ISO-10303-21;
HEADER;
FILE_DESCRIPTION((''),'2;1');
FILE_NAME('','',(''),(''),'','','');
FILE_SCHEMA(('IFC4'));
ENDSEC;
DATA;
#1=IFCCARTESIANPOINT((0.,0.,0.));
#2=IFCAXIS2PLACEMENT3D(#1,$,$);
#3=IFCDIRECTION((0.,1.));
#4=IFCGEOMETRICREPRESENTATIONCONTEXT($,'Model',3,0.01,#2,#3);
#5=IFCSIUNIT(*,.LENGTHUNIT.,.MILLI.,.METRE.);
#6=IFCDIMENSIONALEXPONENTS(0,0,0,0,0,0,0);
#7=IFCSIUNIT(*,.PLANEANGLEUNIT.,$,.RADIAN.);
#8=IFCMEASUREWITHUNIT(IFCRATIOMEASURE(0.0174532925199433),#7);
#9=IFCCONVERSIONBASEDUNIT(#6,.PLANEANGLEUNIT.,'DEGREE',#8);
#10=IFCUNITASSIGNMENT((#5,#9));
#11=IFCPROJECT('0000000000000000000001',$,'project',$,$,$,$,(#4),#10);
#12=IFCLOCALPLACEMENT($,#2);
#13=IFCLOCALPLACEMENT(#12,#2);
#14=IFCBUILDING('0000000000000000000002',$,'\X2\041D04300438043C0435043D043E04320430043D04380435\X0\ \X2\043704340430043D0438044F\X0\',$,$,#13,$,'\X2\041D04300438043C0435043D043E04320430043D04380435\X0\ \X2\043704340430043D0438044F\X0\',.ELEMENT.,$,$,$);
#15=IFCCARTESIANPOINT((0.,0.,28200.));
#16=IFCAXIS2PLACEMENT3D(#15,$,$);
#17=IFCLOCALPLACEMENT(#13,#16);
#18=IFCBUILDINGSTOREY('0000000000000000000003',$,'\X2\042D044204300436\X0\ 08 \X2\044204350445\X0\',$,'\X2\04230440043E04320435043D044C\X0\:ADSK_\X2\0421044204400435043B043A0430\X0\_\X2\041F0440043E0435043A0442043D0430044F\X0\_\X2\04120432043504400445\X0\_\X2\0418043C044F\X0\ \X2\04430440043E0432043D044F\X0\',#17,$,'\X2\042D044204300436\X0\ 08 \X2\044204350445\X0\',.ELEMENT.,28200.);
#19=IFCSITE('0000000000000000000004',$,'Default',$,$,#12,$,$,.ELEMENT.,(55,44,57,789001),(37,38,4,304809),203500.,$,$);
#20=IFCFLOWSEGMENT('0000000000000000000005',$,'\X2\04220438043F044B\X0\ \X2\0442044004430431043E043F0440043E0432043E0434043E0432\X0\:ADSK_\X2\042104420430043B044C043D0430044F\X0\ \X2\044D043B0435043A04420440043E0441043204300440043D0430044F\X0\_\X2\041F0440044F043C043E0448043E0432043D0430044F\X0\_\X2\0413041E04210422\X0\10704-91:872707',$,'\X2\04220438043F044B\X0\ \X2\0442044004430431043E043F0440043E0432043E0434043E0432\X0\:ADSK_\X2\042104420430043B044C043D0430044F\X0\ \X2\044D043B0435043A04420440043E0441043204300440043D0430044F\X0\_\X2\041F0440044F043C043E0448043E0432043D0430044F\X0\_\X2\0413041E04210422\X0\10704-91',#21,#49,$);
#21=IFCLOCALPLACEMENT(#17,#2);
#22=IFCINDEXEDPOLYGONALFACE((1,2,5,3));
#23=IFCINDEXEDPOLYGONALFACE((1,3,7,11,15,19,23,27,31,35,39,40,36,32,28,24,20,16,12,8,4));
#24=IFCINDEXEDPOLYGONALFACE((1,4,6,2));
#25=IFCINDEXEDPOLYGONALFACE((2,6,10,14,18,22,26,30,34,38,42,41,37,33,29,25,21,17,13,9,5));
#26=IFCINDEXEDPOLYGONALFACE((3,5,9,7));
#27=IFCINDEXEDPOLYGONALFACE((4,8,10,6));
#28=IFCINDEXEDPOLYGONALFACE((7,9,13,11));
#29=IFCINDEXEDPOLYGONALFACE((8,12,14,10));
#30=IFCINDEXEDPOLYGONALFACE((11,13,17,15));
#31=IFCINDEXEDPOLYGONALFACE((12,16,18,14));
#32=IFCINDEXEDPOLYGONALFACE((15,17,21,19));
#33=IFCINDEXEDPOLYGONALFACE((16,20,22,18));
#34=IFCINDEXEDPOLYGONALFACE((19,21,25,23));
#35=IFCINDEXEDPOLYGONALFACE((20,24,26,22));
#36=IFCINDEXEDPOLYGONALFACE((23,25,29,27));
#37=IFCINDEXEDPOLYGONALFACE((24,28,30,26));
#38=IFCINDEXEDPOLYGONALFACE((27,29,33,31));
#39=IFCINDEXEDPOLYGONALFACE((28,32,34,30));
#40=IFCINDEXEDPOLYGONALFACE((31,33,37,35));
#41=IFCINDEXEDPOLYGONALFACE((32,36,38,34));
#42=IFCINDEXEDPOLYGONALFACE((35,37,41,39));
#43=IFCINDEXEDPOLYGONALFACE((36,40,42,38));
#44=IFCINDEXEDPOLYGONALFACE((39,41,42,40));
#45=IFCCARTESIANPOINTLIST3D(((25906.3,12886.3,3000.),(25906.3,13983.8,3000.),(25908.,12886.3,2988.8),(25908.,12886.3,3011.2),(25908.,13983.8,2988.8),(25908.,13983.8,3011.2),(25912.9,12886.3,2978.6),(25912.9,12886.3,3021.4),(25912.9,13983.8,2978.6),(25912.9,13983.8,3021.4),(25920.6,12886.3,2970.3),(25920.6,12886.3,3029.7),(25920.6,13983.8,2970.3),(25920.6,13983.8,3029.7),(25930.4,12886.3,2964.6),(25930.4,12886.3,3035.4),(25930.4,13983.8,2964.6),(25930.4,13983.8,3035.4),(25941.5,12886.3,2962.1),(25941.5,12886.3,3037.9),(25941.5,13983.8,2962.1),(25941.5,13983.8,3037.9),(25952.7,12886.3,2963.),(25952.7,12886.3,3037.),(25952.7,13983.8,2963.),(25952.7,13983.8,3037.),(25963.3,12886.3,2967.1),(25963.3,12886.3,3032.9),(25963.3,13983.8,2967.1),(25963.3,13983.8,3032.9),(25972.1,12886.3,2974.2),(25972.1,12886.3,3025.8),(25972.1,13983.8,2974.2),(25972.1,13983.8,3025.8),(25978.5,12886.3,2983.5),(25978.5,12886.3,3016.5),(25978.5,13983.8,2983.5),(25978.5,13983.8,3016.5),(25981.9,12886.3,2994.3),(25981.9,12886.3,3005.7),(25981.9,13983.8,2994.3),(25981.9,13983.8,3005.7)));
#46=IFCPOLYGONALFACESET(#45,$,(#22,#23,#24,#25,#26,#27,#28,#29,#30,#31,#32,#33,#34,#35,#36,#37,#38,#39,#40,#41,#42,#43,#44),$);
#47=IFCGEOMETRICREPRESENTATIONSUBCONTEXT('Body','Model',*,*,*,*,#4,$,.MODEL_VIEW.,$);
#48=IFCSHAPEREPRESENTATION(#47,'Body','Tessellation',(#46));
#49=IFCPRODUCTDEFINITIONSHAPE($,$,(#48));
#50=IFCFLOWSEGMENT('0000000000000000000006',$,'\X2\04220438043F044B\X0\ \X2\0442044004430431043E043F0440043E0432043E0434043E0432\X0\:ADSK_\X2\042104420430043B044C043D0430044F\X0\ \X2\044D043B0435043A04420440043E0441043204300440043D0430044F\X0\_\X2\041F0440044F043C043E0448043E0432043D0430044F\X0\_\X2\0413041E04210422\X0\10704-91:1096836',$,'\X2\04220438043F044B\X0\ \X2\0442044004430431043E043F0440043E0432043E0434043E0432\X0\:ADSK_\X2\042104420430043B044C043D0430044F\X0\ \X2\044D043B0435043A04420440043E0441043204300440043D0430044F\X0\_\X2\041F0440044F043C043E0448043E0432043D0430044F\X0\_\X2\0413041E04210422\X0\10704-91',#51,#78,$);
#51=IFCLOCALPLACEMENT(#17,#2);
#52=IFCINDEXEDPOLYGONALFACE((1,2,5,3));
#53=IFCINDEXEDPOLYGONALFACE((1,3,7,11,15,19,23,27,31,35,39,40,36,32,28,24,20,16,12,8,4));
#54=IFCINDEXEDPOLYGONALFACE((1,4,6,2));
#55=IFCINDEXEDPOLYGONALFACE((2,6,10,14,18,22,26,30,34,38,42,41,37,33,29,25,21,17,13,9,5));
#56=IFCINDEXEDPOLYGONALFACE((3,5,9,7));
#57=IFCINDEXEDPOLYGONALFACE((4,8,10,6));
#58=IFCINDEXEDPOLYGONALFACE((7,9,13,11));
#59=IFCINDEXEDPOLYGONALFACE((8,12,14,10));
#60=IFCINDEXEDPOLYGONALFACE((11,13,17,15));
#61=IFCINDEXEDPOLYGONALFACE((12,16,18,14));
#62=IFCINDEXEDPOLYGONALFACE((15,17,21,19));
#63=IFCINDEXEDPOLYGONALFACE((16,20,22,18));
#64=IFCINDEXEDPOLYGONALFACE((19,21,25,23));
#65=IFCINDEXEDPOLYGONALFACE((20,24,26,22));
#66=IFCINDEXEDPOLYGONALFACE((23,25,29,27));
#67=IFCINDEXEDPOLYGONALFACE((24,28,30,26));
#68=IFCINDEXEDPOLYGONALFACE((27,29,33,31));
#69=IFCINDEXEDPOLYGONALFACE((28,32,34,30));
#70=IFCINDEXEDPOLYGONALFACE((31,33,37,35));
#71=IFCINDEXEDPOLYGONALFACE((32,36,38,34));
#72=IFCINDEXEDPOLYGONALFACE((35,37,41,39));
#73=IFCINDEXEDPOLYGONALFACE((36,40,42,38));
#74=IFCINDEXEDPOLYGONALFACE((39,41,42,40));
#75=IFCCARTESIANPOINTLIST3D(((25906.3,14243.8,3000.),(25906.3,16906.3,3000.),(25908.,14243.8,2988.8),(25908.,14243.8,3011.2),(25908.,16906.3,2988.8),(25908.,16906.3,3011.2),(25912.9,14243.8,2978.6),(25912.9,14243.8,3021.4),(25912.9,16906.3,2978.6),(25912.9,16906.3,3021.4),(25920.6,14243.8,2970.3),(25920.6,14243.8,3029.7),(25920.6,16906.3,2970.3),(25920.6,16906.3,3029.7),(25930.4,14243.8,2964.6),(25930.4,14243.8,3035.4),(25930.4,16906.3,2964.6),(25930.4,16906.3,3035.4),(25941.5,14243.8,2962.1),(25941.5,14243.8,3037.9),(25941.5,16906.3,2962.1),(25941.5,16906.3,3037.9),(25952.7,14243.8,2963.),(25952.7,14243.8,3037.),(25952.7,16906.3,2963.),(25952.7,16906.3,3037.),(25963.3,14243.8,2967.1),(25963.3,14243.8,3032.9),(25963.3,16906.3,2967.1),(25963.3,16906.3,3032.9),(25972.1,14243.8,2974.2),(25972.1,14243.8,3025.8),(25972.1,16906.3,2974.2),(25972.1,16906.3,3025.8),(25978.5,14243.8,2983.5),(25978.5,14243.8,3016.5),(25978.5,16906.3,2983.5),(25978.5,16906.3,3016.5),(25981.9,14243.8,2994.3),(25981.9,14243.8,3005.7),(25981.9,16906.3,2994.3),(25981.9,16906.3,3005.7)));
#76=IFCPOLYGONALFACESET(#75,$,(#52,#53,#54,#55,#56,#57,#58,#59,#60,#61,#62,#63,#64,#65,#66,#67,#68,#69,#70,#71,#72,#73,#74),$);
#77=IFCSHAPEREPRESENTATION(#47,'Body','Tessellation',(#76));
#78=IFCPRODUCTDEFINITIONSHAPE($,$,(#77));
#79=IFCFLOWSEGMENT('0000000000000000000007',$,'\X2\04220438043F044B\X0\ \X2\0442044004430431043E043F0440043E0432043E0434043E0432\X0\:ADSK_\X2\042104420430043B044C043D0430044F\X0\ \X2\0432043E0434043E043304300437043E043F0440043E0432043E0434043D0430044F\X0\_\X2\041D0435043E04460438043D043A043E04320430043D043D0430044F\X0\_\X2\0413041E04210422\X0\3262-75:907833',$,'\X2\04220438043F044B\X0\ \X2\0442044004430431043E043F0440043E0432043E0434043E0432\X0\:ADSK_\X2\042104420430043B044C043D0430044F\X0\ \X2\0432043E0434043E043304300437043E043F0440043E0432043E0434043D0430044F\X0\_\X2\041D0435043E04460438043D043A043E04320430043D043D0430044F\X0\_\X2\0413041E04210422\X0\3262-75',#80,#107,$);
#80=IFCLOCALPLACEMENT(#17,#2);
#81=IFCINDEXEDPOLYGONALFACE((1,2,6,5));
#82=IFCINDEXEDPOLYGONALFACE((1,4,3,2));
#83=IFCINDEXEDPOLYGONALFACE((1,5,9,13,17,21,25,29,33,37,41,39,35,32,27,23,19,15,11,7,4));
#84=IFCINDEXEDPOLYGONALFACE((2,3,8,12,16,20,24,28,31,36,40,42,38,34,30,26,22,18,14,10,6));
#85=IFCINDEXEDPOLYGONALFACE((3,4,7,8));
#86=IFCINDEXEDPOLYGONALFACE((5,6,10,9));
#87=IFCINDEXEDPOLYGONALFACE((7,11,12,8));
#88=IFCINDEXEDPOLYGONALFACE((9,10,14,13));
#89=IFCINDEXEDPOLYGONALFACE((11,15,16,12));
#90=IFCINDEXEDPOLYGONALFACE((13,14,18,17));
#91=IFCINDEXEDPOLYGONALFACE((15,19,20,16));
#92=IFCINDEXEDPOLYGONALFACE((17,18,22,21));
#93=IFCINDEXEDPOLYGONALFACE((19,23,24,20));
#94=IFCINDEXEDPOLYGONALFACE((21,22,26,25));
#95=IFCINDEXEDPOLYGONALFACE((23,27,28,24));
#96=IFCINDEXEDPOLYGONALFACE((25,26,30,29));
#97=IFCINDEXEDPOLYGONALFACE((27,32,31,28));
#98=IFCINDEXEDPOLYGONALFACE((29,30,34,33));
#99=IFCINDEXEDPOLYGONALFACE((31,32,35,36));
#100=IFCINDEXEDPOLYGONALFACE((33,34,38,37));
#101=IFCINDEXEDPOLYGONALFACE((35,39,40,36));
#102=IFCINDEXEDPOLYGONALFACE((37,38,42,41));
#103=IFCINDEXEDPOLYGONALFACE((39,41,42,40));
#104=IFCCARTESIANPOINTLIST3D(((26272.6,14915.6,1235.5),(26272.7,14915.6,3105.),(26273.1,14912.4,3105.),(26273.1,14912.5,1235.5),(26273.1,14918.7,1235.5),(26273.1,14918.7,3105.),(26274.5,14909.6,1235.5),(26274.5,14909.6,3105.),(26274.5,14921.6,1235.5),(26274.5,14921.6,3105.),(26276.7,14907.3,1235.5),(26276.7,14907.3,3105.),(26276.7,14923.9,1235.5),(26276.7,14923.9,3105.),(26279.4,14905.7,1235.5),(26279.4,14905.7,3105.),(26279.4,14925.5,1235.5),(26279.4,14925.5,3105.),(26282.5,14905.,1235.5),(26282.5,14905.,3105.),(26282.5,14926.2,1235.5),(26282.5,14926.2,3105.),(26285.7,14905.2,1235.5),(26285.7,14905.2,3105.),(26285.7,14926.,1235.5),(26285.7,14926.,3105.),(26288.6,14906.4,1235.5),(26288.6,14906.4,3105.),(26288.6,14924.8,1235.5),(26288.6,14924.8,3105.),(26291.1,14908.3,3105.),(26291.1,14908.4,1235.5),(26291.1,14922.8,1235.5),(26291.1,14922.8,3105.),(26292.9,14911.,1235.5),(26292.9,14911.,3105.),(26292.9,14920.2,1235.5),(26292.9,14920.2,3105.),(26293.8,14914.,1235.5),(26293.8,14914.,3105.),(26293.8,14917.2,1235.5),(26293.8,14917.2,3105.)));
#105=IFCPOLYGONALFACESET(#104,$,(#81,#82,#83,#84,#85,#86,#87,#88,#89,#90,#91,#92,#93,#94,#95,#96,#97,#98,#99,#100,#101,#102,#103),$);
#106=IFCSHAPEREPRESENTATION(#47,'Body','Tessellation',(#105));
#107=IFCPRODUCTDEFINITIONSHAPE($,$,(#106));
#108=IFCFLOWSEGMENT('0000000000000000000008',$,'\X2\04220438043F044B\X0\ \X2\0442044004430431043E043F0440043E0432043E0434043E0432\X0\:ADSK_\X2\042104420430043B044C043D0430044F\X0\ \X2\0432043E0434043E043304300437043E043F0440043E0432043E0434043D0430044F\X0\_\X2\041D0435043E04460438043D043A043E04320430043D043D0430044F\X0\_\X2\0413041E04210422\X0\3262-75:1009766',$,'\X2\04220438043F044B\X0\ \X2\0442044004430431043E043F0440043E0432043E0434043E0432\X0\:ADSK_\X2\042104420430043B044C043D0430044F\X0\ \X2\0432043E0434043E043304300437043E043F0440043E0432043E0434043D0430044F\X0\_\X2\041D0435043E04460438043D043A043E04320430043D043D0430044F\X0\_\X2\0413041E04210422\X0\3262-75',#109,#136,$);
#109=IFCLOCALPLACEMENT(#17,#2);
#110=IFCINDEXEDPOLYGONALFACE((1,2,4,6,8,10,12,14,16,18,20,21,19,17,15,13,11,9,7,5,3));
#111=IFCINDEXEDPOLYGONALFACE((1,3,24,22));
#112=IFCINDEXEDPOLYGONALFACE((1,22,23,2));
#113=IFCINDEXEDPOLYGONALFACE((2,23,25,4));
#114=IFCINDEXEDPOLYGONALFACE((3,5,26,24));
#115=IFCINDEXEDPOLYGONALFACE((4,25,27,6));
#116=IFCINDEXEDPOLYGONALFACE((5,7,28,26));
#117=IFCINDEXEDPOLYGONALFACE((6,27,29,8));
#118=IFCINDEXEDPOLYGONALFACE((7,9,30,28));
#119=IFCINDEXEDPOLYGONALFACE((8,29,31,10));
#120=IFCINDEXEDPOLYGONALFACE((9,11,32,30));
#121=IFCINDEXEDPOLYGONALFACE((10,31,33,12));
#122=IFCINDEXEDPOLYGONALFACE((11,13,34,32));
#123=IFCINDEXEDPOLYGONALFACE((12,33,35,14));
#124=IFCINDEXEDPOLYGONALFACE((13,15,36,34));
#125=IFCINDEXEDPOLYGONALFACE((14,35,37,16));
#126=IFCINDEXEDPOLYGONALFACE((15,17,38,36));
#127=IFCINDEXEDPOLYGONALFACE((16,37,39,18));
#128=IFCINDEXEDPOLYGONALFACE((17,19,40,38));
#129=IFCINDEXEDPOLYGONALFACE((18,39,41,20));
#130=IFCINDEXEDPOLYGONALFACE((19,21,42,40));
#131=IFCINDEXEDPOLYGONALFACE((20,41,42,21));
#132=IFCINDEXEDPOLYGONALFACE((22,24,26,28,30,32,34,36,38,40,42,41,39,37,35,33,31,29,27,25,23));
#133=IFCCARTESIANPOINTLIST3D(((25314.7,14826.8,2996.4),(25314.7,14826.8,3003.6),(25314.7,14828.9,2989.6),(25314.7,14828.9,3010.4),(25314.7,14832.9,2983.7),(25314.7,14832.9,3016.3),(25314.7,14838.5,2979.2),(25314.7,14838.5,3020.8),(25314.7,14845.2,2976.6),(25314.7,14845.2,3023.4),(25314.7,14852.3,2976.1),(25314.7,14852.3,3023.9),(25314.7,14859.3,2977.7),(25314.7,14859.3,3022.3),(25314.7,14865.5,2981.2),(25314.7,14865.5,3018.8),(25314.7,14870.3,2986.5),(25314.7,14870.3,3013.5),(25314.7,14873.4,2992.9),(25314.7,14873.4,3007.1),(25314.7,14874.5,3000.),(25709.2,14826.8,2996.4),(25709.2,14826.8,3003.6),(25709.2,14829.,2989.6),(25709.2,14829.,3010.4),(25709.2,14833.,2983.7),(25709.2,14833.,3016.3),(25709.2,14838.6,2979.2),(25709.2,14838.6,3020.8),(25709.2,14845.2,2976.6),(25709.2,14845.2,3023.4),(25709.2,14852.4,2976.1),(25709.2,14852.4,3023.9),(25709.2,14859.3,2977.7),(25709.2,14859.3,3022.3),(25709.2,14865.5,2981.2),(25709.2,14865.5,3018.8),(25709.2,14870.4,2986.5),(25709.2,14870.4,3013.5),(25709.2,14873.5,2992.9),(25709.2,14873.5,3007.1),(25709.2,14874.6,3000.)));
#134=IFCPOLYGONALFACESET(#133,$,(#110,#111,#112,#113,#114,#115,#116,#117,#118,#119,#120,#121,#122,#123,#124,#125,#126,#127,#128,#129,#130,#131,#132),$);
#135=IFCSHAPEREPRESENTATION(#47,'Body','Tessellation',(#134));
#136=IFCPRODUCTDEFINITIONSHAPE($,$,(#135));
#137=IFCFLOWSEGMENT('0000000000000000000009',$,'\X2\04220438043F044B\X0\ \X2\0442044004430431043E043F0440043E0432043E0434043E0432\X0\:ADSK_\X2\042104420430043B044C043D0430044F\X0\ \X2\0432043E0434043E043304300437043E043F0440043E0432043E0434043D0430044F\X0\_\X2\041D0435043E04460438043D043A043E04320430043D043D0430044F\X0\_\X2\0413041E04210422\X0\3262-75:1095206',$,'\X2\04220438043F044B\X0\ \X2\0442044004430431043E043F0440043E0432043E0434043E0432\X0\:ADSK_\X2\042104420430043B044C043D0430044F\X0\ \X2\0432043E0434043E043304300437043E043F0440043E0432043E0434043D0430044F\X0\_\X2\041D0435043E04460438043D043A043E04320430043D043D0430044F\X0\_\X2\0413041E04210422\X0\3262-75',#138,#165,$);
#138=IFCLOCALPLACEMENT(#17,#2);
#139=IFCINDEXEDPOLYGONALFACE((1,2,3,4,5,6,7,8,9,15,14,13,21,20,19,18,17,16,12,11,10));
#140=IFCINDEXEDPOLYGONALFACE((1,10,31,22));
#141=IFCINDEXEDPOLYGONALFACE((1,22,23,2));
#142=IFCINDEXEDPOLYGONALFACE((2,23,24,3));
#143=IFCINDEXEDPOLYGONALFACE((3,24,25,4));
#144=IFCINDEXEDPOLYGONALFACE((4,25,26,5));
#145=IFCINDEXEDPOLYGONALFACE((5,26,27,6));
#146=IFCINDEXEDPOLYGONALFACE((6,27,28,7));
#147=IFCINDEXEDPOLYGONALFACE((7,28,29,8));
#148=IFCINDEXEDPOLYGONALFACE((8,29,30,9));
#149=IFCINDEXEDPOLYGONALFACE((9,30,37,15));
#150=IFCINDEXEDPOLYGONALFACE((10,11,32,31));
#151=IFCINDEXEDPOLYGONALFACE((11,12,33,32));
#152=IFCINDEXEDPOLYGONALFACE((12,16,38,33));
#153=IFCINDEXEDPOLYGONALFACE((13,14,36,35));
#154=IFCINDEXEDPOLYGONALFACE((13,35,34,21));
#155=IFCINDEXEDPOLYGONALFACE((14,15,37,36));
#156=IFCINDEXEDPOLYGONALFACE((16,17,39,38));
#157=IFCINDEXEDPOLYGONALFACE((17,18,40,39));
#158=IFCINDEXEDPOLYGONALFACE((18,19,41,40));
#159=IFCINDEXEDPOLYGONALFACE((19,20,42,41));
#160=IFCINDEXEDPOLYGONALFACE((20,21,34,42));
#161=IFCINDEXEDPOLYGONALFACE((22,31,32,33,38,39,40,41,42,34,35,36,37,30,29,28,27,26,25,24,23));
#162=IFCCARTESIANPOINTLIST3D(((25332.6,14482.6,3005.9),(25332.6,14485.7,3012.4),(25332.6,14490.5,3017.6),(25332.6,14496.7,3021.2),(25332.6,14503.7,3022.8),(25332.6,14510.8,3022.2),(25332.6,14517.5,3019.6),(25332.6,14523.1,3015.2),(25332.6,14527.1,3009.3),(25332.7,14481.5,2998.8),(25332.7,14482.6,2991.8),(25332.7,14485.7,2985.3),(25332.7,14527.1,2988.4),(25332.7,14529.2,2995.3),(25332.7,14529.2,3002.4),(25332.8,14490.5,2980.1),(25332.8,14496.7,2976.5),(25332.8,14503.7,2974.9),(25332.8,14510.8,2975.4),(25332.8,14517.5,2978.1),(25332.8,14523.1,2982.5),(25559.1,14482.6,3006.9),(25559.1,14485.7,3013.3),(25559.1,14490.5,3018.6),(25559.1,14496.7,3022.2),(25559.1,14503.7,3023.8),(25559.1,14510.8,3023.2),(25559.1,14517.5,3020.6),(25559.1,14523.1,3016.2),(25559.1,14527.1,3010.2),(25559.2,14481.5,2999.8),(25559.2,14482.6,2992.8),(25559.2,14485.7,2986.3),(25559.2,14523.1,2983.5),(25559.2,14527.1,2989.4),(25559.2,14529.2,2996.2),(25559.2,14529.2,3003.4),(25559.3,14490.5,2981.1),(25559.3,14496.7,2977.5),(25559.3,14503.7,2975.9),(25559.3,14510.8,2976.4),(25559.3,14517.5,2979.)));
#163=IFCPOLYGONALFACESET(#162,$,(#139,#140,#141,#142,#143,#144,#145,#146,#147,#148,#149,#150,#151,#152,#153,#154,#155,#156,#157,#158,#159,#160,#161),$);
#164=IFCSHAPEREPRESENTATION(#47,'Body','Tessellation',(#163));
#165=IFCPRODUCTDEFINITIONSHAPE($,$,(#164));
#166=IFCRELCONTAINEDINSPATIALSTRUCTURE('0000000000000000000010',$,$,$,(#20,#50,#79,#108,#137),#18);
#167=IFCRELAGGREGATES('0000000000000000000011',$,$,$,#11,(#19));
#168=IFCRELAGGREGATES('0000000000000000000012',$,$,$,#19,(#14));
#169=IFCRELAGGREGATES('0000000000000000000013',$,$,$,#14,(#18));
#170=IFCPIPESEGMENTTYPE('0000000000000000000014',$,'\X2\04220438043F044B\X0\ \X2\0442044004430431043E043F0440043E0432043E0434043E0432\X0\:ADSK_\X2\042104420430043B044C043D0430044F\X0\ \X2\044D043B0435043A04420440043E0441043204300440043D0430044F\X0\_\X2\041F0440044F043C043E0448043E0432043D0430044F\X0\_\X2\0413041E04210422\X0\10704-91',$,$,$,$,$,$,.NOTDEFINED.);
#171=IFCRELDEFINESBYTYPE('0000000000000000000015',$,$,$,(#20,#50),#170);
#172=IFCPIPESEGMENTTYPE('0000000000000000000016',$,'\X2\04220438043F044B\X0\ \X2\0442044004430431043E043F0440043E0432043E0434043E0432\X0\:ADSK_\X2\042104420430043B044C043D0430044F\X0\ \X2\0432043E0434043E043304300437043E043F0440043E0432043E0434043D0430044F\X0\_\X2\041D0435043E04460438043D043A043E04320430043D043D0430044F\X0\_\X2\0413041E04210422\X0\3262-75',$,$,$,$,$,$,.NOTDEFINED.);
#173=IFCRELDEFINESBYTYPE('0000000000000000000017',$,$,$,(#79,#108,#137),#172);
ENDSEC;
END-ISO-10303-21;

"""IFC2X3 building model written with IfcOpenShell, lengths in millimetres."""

from ifc_helpers import new_model, entity, si_unit, converted_unit, direction, frame, origin, origin_2d_with_axis, place, context, subcontext, project, spatial, circle, extrude, type_object, element, save


model = new_model("IFC2X3")

# Units and contexts
model_context = context("Model", 3, precision=0.01, world=origin(), true_north=direction((0.0, 1.0)))
body_context = subcontext(model_context, "Body", "Model", "MODEL_VIEW")
ifc_project = project(units=[si_unit("LENGTHUNIT", "METRE", prefix="MILLI"), converted_unit("PLANEANGLEUNIT", "DEGREE", entity("IfcRatioMeasure", 0.0174532925199433), si_unit("PLANEANGLEUNIT", "RADIAN"), dimensions=[0, 0, 0, 0, 0, 0, 0])], contexts=[model_context])

# Site, building, storey
site_placement = place(None, origin())
site = spatial("IfcSite", under=ifc_project, at=site_placement, Name="Default", CompositionType="ELEMENT", RefLatitude=(55, 44, 57, 789001), RefLongitude=(37, 38, 4, 304809), RefElevation=203500.0)
building_placement = place(site_placement, origin())
building = spatial("IfcBuilding", under=site, at=building_placement, Name="Наименование здания", LongName="Наименование здания", CompositionType="ELEMENT")
storey_placement = place(building_placement, frame((0.0, 0.0, 28200.0)))
storey = spatial("IfcBuildingStorey", under=building, at=storey_placement, Name="Этаж 08 тех", ObjectType="Уровень:ADSK_Стрелка_Проектная_Вверх_Имя уровня", LongName="Этаж 08 тех", CompositionType="ELEMENT", Elevation=28200.0)

# Flow segments
pipe_segment_type_1 = type_object("IfcPipeSegmentType", Name="Типы трубопроводов:ADSK_Стальная электросварная_Прямошовная_ГОСТ10704-91", PredefinedType="NOTDEFINED")
flow_segment_1_placement = place(storey_placement, frame((25904.7, 12886.3, 2960.4)))
element("IfcFlowSegment", 1, at=flow_segment_1_placement, inside=storey, type_object=pipe_segment_type_1, Name="Типы трубопроводов:ADSK_Стальная электросварная_Прямошовная_ГОСТ10704-91:872707", ObjectType="Типы трубопроводов:ADSK_Стальная электросварная_Прямошовная_ГОСТ10704-91", context=body_context, shape_type="SweptSolid", body=[
    extrude(circle(Radius=38.0, at=origin_2d_with_axis()), frame((39.6, 0.0, 39.6), z_axis=(0.000001, 1.0, 0.0), x_axis=(-1.0, 0.000001, 0.0)), (0.0, 0.0, 1.0), 1097.5),
])
flow_segment_2_placement = place(storey_placement, frame((25904.7, 14243.8, 2960.4)))
element("IfcFlowSegment", 2, at=flow_segment_2_placement, inside=storey, type_object=pipe_segment_type_1, Name="Типы трубопроводов:ADSK_Стальная электросварная_Прямошовная_ГОСТ10704-91:1096836", ObjectType="Типы трубопроводов:ADSK_Стальная электросварная_Прямошовная_ГОСТ10704-91", context=body_context, shape_type="SweptSolid", body=[
    extrude(circle(Radius=38.0, at=origin_2d_with_axis()), frame((39.6, 0.0, 39.6), z_axis=(0.000001, 1.0, 0.0), x_axis=(-1.0, 0.000001, 0.0)), (0.0, 0.0, 1.0), 2662.5),
])
pipe_segment_type_2 = type_object("IfcPipeSegmentType", Name="Типы трубопроводов:ADSK_Стальная водогазопроводная_Неоцинкованная_ГОСТ3262-75", PredefinedType="NOTDEFINED")
flow_segment_3_placement = place(storey_placement, frame((26271.0, 14903.3, 1235.5)))
element("IfcFlowSegment", 3, at=flow_segment_3_placement, inside=storey, type_object=pipe_segment_type_2, Name="Типы трубопроводов:ADSK_Стальная водогазопроводная_Неоцинкованная_ГОСТ3262-75:907833", ObjectType="Типы трубопроводов:ADSK_Стальная водогазопроводная_Неоцинкованная_ГОСТ3262-75", context=body_context, shape_type="SweptSolid", body=[
    extrude(circle(Radius=10.7, at=origin_2d_with_axis()), frame((12.2, 12.3, 0.0), z_axis=(0.0, -0.000011, 1.0), x_axis=(-1.0, 0.0, 0.0)), (0.0, 0.0, 1.0), 1869.5),
])
flow_segment_4_placement = place(storey_placement, frame((25314.7, 14824.9, 2974.4)))
element("IfcFlowSegment", 4, at=flow_segment_4_placement, inside=storey, type_object=pipe_segment_type_2, Name="Типы трубопроводов:ADSK_Стальная водогазопроводная_Неоцинкованная_ГОСТ3262-75:1009766", ObjectType="Типы трубопроводов:ADSK_Стальная водогазопроводная_Неоцинкованная_ГОСТ3262-75", context=body_context, shape_type="SweptSolid", body=[
    extrude(circle(Radius=24.0, at=origin_2d_with_axis()), frame((0.0, 25.6, 25.6), z_axis=(1.0, 0.000169, 0.0), x_axis=(-0.000169, 1.0, 0.0)), (0.0, 0.0, 1.0), 394.5),
])
flow_segment_5_placement = place(storey_placement, frame((25332.6, 14479.9, 2973.2)))
element("IfcFlowSegment", 5, at=flow_segment_5_placement, inside=storey, type_object=pipe_segment_type_2, Name="Типы трубопроводов:ADSK_Стальная водогазопроводная_Неоцинкованная_ГОСТ3262-75:1095206", ObjectType="Типы трубопроводов:ADSK_Стальная водогазопроводная_Неоцинкованная_ГОСТ3262-75", context=body_context, shape_type="SweptSolid", body=[
    extrude(circle(Radius=24.0, at=origin_2d_with_axis()), frame((0.1, 25.6, 25.6), z_axis=(0.999991, 0.0, 0.004353), x_axis=(0.0, -1.0, 0.0)), (0.0, 0.0, 1.0), 226.5),
])

save(model, "model.ifc")
